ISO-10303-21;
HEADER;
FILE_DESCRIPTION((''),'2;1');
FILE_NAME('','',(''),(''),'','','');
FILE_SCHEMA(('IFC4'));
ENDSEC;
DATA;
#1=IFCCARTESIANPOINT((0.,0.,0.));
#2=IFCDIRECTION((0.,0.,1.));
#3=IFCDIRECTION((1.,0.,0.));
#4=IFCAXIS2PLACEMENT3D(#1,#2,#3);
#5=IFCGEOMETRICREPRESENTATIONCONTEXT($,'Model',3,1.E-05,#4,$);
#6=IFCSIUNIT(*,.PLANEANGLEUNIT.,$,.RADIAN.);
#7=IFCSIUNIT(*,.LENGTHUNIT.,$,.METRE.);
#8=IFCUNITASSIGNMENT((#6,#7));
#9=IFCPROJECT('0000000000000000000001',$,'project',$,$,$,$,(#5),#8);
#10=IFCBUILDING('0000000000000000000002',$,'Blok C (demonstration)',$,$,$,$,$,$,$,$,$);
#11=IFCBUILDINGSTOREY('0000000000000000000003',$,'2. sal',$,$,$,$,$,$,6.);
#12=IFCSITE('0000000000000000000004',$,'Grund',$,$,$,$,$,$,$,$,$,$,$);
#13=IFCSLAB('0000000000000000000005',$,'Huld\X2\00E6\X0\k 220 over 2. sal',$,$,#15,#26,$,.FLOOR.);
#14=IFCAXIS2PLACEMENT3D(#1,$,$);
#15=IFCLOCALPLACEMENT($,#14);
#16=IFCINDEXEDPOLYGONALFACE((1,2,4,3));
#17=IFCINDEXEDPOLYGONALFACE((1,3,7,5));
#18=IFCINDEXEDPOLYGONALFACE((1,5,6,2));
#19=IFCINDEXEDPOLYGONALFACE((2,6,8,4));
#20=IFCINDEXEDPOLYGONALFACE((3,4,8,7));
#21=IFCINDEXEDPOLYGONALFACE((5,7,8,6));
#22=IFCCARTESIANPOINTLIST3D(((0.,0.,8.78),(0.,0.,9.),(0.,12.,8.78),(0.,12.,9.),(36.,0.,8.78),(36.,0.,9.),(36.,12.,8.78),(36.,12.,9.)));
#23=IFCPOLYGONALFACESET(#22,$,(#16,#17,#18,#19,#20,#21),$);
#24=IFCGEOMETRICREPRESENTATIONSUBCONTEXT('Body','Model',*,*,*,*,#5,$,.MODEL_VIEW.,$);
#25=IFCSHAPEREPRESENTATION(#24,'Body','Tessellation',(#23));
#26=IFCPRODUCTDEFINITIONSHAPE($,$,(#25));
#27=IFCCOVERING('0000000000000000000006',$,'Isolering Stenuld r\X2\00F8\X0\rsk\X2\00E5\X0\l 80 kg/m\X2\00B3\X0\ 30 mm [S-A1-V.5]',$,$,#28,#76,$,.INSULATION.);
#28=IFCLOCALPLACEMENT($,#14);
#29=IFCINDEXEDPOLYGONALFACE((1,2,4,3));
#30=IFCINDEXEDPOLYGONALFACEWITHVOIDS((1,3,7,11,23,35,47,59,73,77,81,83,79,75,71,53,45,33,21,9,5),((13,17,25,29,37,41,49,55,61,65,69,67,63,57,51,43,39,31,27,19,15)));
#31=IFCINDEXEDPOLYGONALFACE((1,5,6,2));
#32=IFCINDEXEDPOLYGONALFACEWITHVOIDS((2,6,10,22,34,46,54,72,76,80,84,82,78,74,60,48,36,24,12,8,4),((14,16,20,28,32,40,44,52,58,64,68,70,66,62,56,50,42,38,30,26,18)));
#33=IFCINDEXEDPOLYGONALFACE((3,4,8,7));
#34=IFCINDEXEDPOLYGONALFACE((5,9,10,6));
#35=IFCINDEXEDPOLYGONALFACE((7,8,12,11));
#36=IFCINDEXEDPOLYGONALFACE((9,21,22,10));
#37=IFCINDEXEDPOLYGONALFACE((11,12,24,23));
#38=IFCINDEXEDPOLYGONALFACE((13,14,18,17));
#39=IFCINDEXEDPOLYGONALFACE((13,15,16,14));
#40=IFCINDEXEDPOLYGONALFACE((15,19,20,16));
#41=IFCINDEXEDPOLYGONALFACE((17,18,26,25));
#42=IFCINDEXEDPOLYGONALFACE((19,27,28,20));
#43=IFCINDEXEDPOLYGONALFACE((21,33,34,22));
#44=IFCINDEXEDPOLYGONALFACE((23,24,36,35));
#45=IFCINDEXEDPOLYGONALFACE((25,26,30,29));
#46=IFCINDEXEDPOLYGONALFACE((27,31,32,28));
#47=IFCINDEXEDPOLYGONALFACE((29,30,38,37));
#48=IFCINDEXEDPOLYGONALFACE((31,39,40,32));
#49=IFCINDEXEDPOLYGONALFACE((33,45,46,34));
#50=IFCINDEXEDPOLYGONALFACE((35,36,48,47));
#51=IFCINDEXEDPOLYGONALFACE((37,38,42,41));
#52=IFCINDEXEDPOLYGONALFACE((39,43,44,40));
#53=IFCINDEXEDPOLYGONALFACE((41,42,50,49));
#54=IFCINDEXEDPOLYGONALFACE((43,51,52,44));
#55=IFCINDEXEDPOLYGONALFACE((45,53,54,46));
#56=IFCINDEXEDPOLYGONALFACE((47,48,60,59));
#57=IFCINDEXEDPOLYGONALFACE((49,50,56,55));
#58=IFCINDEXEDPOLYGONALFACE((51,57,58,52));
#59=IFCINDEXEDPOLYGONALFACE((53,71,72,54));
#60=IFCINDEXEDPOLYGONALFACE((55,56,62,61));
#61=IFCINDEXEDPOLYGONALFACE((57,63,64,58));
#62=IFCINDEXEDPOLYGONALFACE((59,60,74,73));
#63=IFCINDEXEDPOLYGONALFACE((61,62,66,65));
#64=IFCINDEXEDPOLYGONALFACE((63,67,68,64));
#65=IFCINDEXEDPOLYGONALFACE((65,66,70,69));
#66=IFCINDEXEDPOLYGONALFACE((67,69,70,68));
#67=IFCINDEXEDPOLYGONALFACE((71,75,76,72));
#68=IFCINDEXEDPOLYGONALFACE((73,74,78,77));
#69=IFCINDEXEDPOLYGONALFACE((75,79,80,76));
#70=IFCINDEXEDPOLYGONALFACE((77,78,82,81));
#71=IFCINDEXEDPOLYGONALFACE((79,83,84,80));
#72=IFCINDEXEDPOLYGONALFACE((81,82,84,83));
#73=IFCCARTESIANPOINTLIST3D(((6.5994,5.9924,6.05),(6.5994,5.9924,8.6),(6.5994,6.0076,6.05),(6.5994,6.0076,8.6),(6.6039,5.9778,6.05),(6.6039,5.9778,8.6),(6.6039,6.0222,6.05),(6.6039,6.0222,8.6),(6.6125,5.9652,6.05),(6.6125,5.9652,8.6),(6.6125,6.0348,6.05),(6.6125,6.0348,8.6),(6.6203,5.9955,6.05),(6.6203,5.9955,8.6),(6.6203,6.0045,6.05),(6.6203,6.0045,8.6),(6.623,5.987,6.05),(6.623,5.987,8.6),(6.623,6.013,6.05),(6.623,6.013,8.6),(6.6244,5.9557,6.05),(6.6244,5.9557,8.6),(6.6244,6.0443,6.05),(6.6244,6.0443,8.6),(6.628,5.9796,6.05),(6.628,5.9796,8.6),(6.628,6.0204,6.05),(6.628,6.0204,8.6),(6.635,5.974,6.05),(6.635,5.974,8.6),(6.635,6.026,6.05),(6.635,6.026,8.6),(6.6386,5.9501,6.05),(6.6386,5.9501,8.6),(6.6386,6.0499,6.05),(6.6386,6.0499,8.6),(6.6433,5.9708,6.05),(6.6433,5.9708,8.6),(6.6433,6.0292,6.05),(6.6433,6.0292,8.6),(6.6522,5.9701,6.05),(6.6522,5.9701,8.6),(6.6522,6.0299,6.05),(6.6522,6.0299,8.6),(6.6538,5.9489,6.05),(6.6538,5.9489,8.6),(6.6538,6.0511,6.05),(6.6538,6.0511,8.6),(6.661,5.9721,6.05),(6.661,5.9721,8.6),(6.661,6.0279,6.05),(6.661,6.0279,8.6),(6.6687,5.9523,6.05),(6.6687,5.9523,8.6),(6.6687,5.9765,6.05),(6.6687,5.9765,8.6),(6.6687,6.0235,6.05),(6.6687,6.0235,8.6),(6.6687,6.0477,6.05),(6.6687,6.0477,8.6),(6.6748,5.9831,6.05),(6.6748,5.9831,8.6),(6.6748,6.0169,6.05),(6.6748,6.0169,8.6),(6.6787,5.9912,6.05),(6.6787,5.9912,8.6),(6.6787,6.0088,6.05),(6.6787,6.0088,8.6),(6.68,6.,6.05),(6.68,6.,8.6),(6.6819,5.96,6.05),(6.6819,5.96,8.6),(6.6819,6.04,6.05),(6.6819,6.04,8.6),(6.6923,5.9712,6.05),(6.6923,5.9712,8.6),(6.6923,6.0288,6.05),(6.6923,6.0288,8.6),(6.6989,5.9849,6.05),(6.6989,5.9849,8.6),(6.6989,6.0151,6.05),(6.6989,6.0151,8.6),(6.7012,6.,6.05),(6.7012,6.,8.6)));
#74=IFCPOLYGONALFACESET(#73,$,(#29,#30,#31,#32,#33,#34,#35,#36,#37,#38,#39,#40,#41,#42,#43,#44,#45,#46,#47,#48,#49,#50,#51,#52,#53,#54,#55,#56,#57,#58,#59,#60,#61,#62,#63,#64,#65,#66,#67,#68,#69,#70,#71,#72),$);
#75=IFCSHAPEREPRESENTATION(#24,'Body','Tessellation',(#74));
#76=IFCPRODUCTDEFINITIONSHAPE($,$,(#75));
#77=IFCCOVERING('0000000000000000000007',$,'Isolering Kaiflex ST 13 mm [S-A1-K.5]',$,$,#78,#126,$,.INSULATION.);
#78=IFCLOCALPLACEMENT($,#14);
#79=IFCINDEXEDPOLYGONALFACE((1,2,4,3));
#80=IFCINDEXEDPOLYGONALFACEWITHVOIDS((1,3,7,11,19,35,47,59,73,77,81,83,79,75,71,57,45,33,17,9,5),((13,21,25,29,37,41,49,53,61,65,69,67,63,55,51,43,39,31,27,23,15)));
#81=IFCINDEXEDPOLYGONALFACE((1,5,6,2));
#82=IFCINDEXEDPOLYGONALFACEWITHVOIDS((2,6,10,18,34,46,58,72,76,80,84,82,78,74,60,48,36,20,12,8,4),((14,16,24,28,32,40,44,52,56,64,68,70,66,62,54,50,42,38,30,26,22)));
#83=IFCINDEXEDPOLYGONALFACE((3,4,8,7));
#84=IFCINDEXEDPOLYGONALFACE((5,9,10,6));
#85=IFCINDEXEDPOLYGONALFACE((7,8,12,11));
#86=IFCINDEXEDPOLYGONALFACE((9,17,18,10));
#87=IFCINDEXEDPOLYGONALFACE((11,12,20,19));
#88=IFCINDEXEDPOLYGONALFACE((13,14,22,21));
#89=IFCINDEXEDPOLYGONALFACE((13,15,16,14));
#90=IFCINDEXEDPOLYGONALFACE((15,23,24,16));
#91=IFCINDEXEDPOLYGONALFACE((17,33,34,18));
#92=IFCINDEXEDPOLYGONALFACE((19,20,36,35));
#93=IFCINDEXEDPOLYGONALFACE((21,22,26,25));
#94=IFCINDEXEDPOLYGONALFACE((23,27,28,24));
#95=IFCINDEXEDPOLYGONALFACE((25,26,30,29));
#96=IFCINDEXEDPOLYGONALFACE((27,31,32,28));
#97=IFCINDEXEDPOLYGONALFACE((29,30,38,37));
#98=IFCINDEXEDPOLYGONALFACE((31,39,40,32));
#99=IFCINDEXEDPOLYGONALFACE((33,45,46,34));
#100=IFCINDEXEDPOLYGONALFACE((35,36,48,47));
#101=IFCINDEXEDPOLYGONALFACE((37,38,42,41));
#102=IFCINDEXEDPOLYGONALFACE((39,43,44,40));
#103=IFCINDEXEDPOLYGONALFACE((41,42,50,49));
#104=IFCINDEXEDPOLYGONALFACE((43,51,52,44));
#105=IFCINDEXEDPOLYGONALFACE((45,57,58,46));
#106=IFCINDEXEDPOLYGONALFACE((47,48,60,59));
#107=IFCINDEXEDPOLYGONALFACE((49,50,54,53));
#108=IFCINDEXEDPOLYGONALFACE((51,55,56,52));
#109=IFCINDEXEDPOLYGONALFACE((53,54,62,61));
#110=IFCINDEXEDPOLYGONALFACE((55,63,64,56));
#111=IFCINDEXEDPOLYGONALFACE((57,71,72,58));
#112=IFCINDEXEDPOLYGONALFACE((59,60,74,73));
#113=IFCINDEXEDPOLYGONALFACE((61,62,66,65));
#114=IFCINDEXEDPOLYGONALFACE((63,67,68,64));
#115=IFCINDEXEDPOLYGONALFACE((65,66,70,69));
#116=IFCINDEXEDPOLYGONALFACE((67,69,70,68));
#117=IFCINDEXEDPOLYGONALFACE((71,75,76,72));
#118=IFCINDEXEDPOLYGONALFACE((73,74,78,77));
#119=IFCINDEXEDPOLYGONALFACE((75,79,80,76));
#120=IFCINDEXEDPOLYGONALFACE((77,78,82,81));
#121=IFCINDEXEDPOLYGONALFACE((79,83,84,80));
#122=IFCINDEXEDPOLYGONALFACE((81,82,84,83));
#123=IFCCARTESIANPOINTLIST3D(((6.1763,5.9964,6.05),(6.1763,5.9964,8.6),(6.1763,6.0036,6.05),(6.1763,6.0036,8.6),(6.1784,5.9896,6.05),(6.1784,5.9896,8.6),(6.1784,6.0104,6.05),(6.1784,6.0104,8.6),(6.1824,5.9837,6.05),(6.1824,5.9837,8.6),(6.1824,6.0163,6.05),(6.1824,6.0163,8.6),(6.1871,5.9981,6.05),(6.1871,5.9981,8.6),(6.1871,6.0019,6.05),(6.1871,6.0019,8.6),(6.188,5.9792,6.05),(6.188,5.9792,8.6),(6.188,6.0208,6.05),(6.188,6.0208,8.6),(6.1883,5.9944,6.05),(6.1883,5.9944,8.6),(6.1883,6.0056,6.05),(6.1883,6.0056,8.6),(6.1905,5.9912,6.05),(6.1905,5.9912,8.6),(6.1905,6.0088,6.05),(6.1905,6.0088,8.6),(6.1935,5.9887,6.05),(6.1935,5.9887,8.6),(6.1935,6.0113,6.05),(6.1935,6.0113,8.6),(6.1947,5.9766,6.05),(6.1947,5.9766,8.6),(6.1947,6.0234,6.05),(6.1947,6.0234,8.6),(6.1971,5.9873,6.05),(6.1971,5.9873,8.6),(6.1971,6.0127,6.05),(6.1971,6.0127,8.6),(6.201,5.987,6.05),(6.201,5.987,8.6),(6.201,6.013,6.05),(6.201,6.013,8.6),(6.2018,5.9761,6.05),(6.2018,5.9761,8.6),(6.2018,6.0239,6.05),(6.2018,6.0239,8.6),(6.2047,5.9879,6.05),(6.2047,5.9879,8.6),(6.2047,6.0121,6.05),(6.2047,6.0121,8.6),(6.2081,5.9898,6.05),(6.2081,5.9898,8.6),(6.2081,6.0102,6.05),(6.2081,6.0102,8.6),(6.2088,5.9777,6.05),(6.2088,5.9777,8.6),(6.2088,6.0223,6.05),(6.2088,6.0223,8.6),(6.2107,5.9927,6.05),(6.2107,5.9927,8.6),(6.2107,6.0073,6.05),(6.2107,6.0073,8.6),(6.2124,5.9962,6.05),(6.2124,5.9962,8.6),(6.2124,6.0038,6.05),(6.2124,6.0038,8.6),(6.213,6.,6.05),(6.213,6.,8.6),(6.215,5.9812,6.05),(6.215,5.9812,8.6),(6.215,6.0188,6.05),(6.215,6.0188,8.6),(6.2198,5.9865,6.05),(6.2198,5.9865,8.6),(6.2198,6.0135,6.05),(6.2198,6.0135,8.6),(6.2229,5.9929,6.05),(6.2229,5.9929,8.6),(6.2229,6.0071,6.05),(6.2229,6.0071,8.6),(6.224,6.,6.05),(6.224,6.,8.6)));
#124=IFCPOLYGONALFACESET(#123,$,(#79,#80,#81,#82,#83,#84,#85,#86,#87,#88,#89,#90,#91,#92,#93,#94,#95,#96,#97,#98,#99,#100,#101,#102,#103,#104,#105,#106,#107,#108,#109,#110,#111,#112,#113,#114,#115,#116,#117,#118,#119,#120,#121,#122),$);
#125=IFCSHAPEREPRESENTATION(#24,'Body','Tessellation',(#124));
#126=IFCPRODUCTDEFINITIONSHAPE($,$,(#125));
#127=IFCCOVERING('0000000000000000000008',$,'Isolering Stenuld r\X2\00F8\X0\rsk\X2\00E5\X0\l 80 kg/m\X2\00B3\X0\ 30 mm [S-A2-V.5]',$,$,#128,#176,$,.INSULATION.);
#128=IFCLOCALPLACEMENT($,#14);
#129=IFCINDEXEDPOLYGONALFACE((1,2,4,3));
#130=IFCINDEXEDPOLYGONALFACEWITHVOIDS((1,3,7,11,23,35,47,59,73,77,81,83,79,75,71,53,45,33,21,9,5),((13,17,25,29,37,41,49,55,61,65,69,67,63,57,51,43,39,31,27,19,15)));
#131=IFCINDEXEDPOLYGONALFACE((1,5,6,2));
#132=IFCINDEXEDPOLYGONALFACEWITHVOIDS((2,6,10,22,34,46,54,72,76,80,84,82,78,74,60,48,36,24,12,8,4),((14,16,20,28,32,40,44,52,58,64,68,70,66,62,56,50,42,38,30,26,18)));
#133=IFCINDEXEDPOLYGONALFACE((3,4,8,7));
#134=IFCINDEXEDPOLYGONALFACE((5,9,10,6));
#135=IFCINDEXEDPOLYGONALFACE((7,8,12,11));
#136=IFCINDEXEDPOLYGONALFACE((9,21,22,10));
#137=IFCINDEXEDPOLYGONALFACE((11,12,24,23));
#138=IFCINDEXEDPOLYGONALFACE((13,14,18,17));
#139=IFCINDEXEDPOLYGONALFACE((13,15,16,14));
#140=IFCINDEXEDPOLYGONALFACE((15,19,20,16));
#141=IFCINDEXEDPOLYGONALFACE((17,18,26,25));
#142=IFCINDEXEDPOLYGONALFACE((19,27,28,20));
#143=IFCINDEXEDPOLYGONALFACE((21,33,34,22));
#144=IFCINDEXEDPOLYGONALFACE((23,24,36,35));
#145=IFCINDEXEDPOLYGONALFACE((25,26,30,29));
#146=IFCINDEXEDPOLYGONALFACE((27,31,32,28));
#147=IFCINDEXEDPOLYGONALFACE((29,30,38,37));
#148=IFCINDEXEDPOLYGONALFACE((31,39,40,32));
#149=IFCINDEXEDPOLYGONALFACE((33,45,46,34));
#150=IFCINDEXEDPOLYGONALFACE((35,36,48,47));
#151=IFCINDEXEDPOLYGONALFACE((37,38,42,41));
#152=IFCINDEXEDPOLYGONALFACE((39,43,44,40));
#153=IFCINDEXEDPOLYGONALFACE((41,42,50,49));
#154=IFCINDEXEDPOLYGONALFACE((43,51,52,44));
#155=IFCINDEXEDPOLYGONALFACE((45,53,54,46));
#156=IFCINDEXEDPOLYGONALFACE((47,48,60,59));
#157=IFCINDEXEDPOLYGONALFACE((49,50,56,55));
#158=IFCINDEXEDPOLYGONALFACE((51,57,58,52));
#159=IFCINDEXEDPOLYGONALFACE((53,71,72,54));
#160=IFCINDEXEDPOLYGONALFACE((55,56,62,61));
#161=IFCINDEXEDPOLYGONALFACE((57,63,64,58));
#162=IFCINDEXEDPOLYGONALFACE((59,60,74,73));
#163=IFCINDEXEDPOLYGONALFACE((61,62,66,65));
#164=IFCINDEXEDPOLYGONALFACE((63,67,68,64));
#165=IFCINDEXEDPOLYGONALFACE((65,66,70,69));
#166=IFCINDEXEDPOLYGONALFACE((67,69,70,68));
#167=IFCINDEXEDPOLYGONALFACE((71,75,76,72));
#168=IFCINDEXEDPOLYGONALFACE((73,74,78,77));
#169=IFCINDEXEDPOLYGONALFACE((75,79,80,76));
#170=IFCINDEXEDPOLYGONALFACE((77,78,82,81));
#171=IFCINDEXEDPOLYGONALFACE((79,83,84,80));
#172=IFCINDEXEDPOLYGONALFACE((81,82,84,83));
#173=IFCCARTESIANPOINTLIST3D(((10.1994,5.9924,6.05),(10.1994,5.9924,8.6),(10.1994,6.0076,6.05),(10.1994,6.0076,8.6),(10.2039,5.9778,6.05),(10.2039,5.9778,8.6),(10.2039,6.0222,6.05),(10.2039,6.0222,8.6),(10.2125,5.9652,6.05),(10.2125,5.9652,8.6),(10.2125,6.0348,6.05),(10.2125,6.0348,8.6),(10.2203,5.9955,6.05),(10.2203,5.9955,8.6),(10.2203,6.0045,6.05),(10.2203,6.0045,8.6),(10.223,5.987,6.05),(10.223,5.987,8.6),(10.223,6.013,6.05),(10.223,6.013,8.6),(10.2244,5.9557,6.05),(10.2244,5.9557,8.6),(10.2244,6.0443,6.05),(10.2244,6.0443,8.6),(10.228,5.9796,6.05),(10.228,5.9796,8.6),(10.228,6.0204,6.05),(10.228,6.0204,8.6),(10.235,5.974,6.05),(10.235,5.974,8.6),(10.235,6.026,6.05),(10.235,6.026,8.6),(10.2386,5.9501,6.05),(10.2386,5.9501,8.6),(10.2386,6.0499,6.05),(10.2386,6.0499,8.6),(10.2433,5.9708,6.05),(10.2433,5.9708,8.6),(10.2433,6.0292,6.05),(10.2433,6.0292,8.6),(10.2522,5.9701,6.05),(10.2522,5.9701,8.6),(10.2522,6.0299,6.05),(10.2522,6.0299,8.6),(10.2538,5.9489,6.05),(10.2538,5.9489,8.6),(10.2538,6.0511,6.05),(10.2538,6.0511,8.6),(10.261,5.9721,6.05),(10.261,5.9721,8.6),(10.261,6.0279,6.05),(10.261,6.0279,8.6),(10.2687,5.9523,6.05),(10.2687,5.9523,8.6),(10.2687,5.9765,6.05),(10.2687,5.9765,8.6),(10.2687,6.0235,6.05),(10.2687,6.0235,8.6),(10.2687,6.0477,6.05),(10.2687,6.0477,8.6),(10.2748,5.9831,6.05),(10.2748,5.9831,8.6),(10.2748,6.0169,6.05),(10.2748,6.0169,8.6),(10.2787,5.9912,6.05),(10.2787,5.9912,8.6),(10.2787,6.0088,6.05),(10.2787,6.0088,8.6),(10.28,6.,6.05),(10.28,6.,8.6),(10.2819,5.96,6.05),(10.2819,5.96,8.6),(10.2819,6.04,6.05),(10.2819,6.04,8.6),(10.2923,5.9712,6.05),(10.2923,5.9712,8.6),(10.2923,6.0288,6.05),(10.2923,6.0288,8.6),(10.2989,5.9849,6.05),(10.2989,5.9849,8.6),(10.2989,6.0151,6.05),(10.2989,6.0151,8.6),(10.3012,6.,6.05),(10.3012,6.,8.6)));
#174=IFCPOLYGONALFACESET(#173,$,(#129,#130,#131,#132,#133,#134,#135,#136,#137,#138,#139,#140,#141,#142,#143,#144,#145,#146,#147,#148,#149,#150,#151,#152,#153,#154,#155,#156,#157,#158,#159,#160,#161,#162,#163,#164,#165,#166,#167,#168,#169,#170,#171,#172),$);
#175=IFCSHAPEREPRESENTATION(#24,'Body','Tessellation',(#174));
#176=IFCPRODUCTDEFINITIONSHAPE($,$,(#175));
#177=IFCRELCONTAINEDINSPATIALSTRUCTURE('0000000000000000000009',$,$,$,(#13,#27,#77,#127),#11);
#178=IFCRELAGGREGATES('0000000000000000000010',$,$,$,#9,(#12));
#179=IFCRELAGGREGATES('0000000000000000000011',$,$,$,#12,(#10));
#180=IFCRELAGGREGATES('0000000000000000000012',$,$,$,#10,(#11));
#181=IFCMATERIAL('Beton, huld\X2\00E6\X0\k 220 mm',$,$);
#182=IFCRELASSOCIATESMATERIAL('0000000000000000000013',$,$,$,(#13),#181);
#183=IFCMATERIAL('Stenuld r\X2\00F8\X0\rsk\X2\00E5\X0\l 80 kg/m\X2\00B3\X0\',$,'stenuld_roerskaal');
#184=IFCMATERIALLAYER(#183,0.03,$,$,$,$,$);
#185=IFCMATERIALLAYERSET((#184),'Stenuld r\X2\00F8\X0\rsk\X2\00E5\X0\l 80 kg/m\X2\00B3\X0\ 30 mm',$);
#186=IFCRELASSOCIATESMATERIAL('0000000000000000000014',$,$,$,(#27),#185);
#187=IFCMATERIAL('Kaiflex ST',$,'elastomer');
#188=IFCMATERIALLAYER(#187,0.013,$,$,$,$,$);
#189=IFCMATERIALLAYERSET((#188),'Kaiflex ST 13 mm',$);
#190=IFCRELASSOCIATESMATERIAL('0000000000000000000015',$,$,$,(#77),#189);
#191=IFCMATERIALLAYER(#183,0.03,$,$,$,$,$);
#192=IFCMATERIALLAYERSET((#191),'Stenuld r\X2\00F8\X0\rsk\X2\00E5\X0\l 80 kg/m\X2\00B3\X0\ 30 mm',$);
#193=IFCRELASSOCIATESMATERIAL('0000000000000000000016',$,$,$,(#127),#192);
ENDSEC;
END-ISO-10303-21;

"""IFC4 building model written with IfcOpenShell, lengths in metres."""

from ifc_helpers import new_model, si_unit, frame, origin_with_axes, place, context, subcontext, project, spatial, polyline, hollow_circle, outline, extrude, material, layer, layer_set, element, save


model = new_model("IFC4")

# Units and contexts
model_context = context("Model", 3, precision=1e-05, world=origin_with_axes())
body_context = subcontext(model_context, "Body", "Model", "MODEL_VIEW")
ifc_project = project(units=[si_unit("PLANEANGLEUNIT", "RADIAN"), si_unit("LENGTHUNIT", "METRE")], contexts=[model_context])

# Site, building, storey
site = spatial("IfcSite", under=ifc_project, Name="Grund")
building = spatial("IfcBuilding", under=site, Name="Blok C (demonstration)")
storey = spatial("IfcBuildingStorey", under=building, Name="2. sal", Elevation=6.0)

# Slab
ifc_material_1 = material(Name="Beton, huldæk 220 mm")
slab_placement = place(None, origin_with_axes())
element("IfcSlab", 1, at=slab_placement, inside=storey, material=ifc_material_1, Name="Huldæk 220 over 2. sal", PredefinedType="FLOOR", context=body_context, shape_type="SweptSolid", body=[
    extrude(outline(polyline([(0.0, 0.0), (36.0, 0.0), (36.0, 12.0), (0.0, 12.0), (0.0, 0.0)])), frame((0.0, 0.0, 8.78)), (0.0, 0.0, 1.0), 0.22),
])

# Coverings
ifc_material_2 = material(Name="Stenuld rørskål 80 kg/m³", Category="stenuld_roerskaal")
ifc_layer_1 = layer(ifc_material_2, 0.03)
ifc_layer_set_1 = layer_set([ifc_layer_1], Name="Stenuld rørskål 80 kg/m³ 30 mm")
covering_1_placement = place(None, origin_with_axes())
element("IfcCovering", 2, at=covering_1_placement, inside=storey, material=ifc_layer_set_1, Name="Isolering Stenuld rørskål 80 kg/m³ 30 mm [S-A1-V.5]", PredefinedType="INSULATION", context=body_context, shape_type="SweptSolid", body=[
    extrude(hollow_circle(Radius=0.0512, WallThickness=0.0212), frame((6.65, 6.0, 6.05), z_axis=(0.0, 0.0, 1.0), x_axis=(1.0, 0.0, 0.0)), (0.0, 0.0, 1.0), 2.55),
])
ifc_material_3 = material(Name="Kaiflex ST", Category="elastomer")
ifc_layer_2 = layer(ifc_material_3, 0.013)
ifc_layer_set_2 = layer_set([ifc_layer_2], Name="Kaiflex ST 13 mm")
covering_2_placement = place(None, origin_with_axes())
element("IfcCovering", 3, at=covering_2_placement, inside=storey, material=ifc_layer_set_2, Name="Isolering Kaiflex ST 13 mm [S-A1-K.5]", PredefinedType="INSULATION", context=body_context, shape_type="SweptSolid", body=[
    extrude(hollow_circle(Radius=0.024, WallThickness=0.011), frame((6.2, 6.0, 6.05), z_axis=(0.0, 0.0, 1.0), x_axis=(1.0, 0.0, 0.0)), (0.0, 0.0, 1.0), 2.55),
])
ifc_layer_3 = layer(ifc_material_2, 0.03)
ifc_layer_set_3 = layer_set([ifc_layer_3], Name="Stenuld rørskål 80 kg/m³ 30 mm")
covering_3_placement = place(None, origin_with_axes())
element("IfcCovering", 4, at=covering_3_placement, inside=storey, material=ifc_layer_set_3, Name="Isolering Stenuld rørskål 80 kg/m³ 30 mm [S-A2-V.5]", PredefinedType="INSULATION", context=body_context, shape_type="SweptSolid", body=[
    extrude(hollow_circle(Radius=0.0512, WallThickness=0.0212), frame((10.25, 6.0, 6.05), z_axis=(0.0, 0.0, 1.0), x_axis=(1.0, 0.0, 0.0)), (0.0, 0.0, 1.0), 2.55),
])

save(model, "model.ifc")
